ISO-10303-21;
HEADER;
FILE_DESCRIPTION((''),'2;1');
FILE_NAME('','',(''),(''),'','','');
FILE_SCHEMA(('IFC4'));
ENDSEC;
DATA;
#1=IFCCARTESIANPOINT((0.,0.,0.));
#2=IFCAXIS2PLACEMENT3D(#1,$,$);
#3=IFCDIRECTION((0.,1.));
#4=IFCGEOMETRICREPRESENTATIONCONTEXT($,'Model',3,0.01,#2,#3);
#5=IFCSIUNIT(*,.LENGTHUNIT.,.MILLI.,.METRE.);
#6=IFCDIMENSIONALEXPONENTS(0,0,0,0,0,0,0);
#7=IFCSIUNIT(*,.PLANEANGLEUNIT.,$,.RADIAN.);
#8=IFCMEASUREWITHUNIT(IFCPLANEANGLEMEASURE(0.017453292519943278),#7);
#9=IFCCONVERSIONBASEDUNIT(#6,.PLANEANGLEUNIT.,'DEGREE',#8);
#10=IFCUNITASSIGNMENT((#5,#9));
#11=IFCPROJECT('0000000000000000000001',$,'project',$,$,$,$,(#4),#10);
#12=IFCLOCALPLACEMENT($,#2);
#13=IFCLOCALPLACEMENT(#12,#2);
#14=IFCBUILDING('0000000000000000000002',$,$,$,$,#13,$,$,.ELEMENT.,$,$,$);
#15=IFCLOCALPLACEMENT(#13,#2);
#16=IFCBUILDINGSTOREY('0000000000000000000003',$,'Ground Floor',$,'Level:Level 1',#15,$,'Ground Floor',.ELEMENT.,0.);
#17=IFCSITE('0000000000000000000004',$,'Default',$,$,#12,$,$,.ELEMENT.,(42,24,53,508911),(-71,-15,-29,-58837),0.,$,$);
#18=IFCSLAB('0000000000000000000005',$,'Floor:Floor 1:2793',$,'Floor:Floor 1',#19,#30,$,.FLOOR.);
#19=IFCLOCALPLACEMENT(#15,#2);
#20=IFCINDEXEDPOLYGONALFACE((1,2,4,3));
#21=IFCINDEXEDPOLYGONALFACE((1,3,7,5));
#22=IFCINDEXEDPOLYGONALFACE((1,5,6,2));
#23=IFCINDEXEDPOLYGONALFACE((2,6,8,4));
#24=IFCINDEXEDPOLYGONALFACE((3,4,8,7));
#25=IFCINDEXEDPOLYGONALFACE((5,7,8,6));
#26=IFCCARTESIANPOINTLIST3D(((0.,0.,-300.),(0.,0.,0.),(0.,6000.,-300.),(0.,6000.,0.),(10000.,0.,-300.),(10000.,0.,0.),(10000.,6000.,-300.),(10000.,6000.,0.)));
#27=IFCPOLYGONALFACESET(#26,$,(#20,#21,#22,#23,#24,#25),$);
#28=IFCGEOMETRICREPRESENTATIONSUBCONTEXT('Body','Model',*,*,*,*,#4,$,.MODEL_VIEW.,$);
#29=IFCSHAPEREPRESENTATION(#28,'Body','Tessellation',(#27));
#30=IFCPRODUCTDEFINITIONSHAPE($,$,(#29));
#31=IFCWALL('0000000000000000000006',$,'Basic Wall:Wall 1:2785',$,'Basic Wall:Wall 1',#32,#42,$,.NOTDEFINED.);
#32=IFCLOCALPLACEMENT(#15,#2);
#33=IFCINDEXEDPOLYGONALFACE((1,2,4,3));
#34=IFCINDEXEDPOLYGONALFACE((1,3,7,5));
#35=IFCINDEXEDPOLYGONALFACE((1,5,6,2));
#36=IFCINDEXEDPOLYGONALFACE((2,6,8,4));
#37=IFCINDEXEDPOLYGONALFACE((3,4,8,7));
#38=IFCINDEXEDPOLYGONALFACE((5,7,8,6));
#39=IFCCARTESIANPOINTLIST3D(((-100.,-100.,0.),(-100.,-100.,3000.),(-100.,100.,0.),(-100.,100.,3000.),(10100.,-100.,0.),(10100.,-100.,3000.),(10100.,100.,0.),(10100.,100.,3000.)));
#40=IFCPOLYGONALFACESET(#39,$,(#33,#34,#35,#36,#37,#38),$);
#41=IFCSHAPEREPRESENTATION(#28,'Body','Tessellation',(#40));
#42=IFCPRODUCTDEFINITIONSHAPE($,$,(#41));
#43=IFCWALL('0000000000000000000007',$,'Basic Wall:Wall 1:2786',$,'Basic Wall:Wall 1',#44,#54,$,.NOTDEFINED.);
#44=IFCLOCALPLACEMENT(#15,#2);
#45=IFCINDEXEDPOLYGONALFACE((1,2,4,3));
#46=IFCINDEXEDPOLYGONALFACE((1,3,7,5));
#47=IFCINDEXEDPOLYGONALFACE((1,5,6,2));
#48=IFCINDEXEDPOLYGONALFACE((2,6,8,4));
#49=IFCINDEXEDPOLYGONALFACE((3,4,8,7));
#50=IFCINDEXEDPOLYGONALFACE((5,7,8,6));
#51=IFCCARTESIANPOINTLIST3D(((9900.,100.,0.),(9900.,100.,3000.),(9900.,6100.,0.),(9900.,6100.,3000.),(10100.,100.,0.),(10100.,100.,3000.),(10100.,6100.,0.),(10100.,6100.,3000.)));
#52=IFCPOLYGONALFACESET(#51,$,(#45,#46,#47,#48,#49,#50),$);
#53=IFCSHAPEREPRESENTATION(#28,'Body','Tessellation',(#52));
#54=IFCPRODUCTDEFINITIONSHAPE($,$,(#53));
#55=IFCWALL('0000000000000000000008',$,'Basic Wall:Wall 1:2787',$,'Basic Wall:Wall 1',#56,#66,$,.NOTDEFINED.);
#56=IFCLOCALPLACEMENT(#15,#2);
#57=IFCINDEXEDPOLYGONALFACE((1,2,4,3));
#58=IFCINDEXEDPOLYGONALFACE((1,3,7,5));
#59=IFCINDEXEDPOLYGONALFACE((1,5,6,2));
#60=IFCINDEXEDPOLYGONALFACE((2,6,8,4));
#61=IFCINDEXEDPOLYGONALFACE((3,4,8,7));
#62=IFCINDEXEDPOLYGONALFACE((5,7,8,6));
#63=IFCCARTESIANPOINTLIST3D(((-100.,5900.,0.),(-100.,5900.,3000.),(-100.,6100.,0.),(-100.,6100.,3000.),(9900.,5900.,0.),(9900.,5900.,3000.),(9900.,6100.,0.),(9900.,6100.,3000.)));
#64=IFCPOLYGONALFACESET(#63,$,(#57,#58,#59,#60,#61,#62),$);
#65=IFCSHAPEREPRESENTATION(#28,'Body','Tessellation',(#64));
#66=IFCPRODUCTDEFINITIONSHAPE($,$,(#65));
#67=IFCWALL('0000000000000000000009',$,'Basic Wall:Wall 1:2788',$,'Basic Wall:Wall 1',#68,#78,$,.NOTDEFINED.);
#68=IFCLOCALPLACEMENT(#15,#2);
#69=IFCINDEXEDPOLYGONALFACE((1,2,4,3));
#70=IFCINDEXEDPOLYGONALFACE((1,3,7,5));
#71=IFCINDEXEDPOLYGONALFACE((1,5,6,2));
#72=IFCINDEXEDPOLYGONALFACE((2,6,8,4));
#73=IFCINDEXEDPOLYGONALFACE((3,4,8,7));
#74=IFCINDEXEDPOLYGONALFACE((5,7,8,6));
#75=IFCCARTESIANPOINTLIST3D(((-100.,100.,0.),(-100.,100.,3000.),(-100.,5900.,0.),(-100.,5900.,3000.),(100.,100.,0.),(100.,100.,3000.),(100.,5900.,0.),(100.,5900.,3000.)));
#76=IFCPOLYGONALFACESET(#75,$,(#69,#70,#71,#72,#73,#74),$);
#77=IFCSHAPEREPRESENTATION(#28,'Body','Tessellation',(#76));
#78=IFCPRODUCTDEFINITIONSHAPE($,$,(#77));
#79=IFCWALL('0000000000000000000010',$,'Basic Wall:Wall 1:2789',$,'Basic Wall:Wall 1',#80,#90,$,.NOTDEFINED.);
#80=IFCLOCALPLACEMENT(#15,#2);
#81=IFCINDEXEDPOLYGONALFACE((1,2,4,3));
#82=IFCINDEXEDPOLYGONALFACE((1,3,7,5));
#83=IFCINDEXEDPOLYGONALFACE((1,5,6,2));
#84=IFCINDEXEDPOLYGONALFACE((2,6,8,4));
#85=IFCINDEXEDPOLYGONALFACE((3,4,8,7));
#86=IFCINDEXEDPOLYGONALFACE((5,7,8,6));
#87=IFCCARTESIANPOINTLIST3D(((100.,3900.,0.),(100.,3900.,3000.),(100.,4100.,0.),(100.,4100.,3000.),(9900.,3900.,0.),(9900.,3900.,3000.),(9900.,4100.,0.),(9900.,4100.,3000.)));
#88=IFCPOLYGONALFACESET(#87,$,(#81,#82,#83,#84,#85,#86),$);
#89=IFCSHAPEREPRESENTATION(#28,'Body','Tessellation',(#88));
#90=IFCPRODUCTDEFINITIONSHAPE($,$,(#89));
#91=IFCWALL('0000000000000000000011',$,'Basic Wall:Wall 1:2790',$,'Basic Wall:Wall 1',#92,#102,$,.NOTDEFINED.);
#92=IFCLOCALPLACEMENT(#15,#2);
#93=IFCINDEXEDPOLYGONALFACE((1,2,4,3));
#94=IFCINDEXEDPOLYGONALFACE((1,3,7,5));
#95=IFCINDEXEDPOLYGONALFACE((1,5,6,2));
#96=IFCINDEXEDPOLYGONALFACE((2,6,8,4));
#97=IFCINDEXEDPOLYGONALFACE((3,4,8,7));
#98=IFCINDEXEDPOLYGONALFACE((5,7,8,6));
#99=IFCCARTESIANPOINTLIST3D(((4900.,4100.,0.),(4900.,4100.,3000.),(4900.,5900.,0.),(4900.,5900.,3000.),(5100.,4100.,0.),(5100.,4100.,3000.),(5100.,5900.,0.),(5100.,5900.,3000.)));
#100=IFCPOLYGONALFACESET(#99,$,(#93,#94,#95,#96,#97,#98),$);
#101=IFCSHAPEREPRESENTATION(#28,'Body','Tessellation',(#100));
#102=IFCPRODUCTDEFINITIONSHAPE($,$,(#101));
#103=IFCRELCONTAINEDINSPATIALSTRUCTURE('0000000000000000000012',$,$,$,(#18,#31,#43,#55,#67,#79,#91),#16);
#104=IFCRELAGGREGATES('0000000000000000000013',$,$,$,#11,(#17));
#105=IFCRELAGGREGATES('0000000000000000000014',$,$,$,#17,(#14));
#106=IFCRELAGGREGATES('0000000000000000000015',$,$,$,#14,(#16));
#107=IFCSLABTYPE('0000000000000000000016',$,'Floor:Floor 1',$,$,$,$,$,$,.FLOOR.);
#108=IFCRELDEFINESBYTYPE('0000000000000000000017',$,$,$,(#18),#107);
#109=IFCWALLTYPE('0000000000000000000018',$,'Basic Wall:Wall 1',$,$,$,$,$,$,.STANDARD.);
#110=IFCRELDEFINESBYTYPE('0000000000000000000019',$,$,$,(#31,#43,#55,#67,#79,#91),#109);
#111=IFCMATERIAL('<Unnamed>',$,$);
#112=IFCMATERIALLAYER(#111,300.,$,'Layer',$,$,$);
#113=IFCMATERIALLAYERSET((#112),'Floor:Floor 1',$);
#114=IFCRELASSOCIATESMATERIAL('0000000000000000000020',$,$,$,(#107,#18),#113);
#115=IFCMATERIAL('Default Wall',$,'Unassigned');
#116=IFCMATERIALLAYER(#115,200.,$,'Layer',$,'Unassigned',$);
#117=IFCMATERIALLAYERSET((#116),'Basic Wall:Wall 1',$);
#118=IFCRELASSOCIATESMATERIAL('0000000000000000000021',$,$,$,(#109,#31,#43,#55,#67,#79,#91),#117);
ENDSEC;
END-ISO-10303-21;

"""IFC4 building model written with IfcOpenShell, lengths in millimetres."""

from ifc_helpers import new_model, entity, si_unit, converted_unit, direction, frame, frame_2d, origin, origin_2d_with_axis, place, context, subcontext, project, spatial, rectangle, extrude, material, layer, layer_set, layer_usage, type_object, element, save


model = new_model("IFC4")

# Units and contexts
model_context = context("Model", 3, precision=0.01, world=origin(), true_north=direction((0.0, 1.0)))
body_context = subcontext(model_context, "Body", "Model", "MODEL_VIEW")
ifc_project = project(units=[si_unit("LENGTHUNIT", "METRE", prefix="MILLI"), converted_unit("PLANEANGLEUNIT", "DEGREE", entity("IfcPlaneAngleMeasure", 0.017453292519943278), si_unit("PLANEANGLEUNIT", "RADIAN"), dimensions=[0, 0, 0, 0, 0, 0, 0])], contexts=[model_context])

# Site, building, storey
site_placement = place(None, origin())
site = spatial("IfcSite", under=ifc_project, at=site_placement, Name="Default", CompositionType="ELEMENT", RefLatitude=(42, 24, 53, 508911), RefLongitude=(-71, -15, -29, -58837), RefElevation=0.0)
building_placement = place(site_placement, origin())
building = spatial("IfcBuilding", under=site, at=building_placement, CompositionType="ELEMENT")
storey_placement = place(building_placement, origin())
storey = spatial("IfcBuildingStorey", under=building, at=storey_placement, Name="Ground Floor", ObjectType="Level:Level 1", LongName="Ground Floor", CompositionType="ELEMENT", Elevation=0.0)

# Slab
ifc_material_1 = material(Name="<Unnamed>")
ifc_layer_1 = layer(ifc_material_1, 300.0, Name="Layer")
ifc_layer_set_1 = layer_set([ifc_layer_1], Name="Floor:Floor 1")
ifc_layer_usage_1 = layer_usage(ifc_layer_set_1, "AXIS3", "POSITIVE", 0.0)
slab_type = type_object("IfcSlabType", Name="Floor:Floor 1", PredefinedType="FLOOR", material=ifc_layer_set_1)
slab_placement = place(storey_placement, origin())
element("IfcSlab", 1, at=slab_placement, inside=storey, type_object=slab_type, material=ifc_layer_usage_1, Name="Floor:Floor 1:2793", ObjectType="Floor:Floor 1", PredefinedType="FLOOR", context=body_context, shape_type="SweptSolid", body=[
    extrude(rectangle(XDim=6000.0, YDim=10000.0, at=origin_2d_with_axis()), frame((5000.0, 3000.0, 0.0), z_axis=(0.0, 0.0, -1.0), x_axis=(0.0, 1.0, 0.0)), (0.0, 0.0, 1.0), 300.0),
])

# Walls
ifc_material_2 = material(Name="Default Wall", Category="Unassigned")
ifc_layer_2 = layer(ifc_material_2, 200.0, Name="Layer", Category="Unassigned")
ifc_layer_set_2 = layer_set([ifc_layer_2], Name="Basic Wall:Wall 1")
ifc_layer_usage_2 = layer_usage(ifc_layer_set_2, "AXIS2", "NEGATIVE", 100.0)
wall_type = type_object("IfcWallType", Name="Basic Wall:Wall 1", PredefinedType="STANDARD", material=ifc_layer_set_2)
wall_1_placement = place(storey_placement, frame((-100.0, 0.0, 0.0)))
element("IfcWall", 2, at=wall_1_placement, inside=storey, type_object=wall_type, material=ifc_layer_usage_2, Name="Basic Wall:Wall 1:2785", ObjectType="Basic Wall:Wall 1", PredefinedType="NOTDEFINED", context=body_context, shape_type="SweptSolid", body=[
    extrude(rectangle(XDim=10200.0, YDim=200.0, at=frame_2d((5100.0, 0.0), x_axis=(-1.0, 0.0))), origin(), (0.0, 0.0, 1.0), 3000.0),
])
ifc_layer_usage_3 = layer_usage(ifc_layer_set_2, "AXIS2", "NEGATIVE", 100.0)
wall_2_placement = place(storey_placement, frame((10000.0, 100.0, 0.0), z_axis=(0.0, 0.0, 1.0), x_axis=(0.0, 1.0, 0.0)))
element("IfcWall", 3, at=wall_2_placement, inside=storey, type_object=wall_type, material=ifc_layer_usage_3, Name="Basic Wall:Wall 1:2786", ObjectType="Basic Wall:Wall 1", PredefinedType="NOTDEFINED", context=body_context, shape_type="SweptSolid", body=[
    extrude(rectangle(XDim=6000.0, YDim=200.0, at=frame_2d((3000.0, 0.0), x_axis=(-1.0, 0.0))), origin(), (0.0, 0.0, 1.0), 3000.0),
])
ifc_layer_usage_4 = layer_usage(ifc_layer_set_2, "AXIS2", "NEGATIVE", 100.0)
wall_3_placement = place(storey_placement, frame((9900.0, 6000.0, 0.0), z_axis=(0.0, 0.0, 1.0), x_axis=(-1.0, 0.0, 0.0)))
element("IfcWall", 4, at=wall_3_placement, inside=storey, type_object=wall_type, material=ifc_layer_usage_4, Name="Basic Wall:Wall 1:2787", ObjectType="Basic Wall:Wall 1", PredefinedType="NOTDEFINED", context=body_context, shape_type="SweptSolid", body=[
    extrude(rectangle(XDim=10000.0, YDim=200.0, at=frame_2d((5000.0, 0.0), x_axis=(-1.0, 0.0))), origin(), (0.0, 0.0, 1.0), 3000.0),
])
ifc_layer_usage_5 = layer_usage(ifc_layer_set_2, "AXIS2", "NEGATIVE", 100.0)
wall_4_placement = place(storey_placement, frame((0.0, 5900.0, 0.0), z_axis=(0.0, 0.0, 1.0), x_axis=(0.0, -1.0, 0.0)))
element("IfcWall", 5, at=wall_4_placement, inside=storey, type_object=wall_type, material=ifc_layer_usage_5, Name="Basic Wall:Wall 1:2788", ObjectType="Basic Wall:Wall 1", PredefinedType="NOTDEFINED", context=body_context, shape_type="SweptSolid", body=[
    extrude(rectangle(XDim=5800.0, YDim=200.0, at=frame_2d((2900.0, 0.0), x_axis=(-1.0, 0.0))), origin(), (0.0, 0.0, 1.0), 3000.0),
])
ifc_layer_usage_6 = layer_usage(ifc_layer_set_2, "AXIS2", "NEGATIVE", 100.0)
wall_5_placement = place(storey_placement, frame((100.0, 4000.0, 0.0)))
element("IfcWall", 6, at=wall_5_placement, inside=storey, type_object=wall_type, material=ifc_layer_usage_6, Name="Basic Wall:Wall 1:2789", ObjectType="Basic Wall:Wall 1", PredefinedType="NOTDEFINED", context=body_context, shape_type="SweptSolid", body=[
    extrude(rectangle(XDim=9800.0, YDim=200.0, at=frame_2d((4900.0, 0.0), x_axis=(-1.0, 0.0))), origin(), (0.0, 0.0, 1.0), 3000.0),
])
ifc_layer_usage_7 = layer_usage(ifc_layer_set_2, "AXIS2", "NEGATIVE", 100.0)
wall_6_placement = place(storey_placement, frame((5000.0, 4100.0, 0.0), z_axis=(0.0, 0.0, 1.0), x_axis=(0.0, 1.0, 0.0)))
element("IfcWall", 7, at=wall_6_placement, inside=storey, type_object=wall_type, material=ifc_layer_usage_7, Name="Basic Wall:Wall 1:2790", ObjectType="Basic Wall:Wall 1", PredefinedType="NOTDEFINED", context=body_context, shape_type="SweptSolid", body=[
    extrude(rectangle(XDim=1800.0, YDim=200.0, at=frame_2d((900.0, 0.0), x_axis=(-1.0, 0.0))), origin(), (0.0, 0.0, 1.0), 3000.0),
])

save(model, "model.ifc")
